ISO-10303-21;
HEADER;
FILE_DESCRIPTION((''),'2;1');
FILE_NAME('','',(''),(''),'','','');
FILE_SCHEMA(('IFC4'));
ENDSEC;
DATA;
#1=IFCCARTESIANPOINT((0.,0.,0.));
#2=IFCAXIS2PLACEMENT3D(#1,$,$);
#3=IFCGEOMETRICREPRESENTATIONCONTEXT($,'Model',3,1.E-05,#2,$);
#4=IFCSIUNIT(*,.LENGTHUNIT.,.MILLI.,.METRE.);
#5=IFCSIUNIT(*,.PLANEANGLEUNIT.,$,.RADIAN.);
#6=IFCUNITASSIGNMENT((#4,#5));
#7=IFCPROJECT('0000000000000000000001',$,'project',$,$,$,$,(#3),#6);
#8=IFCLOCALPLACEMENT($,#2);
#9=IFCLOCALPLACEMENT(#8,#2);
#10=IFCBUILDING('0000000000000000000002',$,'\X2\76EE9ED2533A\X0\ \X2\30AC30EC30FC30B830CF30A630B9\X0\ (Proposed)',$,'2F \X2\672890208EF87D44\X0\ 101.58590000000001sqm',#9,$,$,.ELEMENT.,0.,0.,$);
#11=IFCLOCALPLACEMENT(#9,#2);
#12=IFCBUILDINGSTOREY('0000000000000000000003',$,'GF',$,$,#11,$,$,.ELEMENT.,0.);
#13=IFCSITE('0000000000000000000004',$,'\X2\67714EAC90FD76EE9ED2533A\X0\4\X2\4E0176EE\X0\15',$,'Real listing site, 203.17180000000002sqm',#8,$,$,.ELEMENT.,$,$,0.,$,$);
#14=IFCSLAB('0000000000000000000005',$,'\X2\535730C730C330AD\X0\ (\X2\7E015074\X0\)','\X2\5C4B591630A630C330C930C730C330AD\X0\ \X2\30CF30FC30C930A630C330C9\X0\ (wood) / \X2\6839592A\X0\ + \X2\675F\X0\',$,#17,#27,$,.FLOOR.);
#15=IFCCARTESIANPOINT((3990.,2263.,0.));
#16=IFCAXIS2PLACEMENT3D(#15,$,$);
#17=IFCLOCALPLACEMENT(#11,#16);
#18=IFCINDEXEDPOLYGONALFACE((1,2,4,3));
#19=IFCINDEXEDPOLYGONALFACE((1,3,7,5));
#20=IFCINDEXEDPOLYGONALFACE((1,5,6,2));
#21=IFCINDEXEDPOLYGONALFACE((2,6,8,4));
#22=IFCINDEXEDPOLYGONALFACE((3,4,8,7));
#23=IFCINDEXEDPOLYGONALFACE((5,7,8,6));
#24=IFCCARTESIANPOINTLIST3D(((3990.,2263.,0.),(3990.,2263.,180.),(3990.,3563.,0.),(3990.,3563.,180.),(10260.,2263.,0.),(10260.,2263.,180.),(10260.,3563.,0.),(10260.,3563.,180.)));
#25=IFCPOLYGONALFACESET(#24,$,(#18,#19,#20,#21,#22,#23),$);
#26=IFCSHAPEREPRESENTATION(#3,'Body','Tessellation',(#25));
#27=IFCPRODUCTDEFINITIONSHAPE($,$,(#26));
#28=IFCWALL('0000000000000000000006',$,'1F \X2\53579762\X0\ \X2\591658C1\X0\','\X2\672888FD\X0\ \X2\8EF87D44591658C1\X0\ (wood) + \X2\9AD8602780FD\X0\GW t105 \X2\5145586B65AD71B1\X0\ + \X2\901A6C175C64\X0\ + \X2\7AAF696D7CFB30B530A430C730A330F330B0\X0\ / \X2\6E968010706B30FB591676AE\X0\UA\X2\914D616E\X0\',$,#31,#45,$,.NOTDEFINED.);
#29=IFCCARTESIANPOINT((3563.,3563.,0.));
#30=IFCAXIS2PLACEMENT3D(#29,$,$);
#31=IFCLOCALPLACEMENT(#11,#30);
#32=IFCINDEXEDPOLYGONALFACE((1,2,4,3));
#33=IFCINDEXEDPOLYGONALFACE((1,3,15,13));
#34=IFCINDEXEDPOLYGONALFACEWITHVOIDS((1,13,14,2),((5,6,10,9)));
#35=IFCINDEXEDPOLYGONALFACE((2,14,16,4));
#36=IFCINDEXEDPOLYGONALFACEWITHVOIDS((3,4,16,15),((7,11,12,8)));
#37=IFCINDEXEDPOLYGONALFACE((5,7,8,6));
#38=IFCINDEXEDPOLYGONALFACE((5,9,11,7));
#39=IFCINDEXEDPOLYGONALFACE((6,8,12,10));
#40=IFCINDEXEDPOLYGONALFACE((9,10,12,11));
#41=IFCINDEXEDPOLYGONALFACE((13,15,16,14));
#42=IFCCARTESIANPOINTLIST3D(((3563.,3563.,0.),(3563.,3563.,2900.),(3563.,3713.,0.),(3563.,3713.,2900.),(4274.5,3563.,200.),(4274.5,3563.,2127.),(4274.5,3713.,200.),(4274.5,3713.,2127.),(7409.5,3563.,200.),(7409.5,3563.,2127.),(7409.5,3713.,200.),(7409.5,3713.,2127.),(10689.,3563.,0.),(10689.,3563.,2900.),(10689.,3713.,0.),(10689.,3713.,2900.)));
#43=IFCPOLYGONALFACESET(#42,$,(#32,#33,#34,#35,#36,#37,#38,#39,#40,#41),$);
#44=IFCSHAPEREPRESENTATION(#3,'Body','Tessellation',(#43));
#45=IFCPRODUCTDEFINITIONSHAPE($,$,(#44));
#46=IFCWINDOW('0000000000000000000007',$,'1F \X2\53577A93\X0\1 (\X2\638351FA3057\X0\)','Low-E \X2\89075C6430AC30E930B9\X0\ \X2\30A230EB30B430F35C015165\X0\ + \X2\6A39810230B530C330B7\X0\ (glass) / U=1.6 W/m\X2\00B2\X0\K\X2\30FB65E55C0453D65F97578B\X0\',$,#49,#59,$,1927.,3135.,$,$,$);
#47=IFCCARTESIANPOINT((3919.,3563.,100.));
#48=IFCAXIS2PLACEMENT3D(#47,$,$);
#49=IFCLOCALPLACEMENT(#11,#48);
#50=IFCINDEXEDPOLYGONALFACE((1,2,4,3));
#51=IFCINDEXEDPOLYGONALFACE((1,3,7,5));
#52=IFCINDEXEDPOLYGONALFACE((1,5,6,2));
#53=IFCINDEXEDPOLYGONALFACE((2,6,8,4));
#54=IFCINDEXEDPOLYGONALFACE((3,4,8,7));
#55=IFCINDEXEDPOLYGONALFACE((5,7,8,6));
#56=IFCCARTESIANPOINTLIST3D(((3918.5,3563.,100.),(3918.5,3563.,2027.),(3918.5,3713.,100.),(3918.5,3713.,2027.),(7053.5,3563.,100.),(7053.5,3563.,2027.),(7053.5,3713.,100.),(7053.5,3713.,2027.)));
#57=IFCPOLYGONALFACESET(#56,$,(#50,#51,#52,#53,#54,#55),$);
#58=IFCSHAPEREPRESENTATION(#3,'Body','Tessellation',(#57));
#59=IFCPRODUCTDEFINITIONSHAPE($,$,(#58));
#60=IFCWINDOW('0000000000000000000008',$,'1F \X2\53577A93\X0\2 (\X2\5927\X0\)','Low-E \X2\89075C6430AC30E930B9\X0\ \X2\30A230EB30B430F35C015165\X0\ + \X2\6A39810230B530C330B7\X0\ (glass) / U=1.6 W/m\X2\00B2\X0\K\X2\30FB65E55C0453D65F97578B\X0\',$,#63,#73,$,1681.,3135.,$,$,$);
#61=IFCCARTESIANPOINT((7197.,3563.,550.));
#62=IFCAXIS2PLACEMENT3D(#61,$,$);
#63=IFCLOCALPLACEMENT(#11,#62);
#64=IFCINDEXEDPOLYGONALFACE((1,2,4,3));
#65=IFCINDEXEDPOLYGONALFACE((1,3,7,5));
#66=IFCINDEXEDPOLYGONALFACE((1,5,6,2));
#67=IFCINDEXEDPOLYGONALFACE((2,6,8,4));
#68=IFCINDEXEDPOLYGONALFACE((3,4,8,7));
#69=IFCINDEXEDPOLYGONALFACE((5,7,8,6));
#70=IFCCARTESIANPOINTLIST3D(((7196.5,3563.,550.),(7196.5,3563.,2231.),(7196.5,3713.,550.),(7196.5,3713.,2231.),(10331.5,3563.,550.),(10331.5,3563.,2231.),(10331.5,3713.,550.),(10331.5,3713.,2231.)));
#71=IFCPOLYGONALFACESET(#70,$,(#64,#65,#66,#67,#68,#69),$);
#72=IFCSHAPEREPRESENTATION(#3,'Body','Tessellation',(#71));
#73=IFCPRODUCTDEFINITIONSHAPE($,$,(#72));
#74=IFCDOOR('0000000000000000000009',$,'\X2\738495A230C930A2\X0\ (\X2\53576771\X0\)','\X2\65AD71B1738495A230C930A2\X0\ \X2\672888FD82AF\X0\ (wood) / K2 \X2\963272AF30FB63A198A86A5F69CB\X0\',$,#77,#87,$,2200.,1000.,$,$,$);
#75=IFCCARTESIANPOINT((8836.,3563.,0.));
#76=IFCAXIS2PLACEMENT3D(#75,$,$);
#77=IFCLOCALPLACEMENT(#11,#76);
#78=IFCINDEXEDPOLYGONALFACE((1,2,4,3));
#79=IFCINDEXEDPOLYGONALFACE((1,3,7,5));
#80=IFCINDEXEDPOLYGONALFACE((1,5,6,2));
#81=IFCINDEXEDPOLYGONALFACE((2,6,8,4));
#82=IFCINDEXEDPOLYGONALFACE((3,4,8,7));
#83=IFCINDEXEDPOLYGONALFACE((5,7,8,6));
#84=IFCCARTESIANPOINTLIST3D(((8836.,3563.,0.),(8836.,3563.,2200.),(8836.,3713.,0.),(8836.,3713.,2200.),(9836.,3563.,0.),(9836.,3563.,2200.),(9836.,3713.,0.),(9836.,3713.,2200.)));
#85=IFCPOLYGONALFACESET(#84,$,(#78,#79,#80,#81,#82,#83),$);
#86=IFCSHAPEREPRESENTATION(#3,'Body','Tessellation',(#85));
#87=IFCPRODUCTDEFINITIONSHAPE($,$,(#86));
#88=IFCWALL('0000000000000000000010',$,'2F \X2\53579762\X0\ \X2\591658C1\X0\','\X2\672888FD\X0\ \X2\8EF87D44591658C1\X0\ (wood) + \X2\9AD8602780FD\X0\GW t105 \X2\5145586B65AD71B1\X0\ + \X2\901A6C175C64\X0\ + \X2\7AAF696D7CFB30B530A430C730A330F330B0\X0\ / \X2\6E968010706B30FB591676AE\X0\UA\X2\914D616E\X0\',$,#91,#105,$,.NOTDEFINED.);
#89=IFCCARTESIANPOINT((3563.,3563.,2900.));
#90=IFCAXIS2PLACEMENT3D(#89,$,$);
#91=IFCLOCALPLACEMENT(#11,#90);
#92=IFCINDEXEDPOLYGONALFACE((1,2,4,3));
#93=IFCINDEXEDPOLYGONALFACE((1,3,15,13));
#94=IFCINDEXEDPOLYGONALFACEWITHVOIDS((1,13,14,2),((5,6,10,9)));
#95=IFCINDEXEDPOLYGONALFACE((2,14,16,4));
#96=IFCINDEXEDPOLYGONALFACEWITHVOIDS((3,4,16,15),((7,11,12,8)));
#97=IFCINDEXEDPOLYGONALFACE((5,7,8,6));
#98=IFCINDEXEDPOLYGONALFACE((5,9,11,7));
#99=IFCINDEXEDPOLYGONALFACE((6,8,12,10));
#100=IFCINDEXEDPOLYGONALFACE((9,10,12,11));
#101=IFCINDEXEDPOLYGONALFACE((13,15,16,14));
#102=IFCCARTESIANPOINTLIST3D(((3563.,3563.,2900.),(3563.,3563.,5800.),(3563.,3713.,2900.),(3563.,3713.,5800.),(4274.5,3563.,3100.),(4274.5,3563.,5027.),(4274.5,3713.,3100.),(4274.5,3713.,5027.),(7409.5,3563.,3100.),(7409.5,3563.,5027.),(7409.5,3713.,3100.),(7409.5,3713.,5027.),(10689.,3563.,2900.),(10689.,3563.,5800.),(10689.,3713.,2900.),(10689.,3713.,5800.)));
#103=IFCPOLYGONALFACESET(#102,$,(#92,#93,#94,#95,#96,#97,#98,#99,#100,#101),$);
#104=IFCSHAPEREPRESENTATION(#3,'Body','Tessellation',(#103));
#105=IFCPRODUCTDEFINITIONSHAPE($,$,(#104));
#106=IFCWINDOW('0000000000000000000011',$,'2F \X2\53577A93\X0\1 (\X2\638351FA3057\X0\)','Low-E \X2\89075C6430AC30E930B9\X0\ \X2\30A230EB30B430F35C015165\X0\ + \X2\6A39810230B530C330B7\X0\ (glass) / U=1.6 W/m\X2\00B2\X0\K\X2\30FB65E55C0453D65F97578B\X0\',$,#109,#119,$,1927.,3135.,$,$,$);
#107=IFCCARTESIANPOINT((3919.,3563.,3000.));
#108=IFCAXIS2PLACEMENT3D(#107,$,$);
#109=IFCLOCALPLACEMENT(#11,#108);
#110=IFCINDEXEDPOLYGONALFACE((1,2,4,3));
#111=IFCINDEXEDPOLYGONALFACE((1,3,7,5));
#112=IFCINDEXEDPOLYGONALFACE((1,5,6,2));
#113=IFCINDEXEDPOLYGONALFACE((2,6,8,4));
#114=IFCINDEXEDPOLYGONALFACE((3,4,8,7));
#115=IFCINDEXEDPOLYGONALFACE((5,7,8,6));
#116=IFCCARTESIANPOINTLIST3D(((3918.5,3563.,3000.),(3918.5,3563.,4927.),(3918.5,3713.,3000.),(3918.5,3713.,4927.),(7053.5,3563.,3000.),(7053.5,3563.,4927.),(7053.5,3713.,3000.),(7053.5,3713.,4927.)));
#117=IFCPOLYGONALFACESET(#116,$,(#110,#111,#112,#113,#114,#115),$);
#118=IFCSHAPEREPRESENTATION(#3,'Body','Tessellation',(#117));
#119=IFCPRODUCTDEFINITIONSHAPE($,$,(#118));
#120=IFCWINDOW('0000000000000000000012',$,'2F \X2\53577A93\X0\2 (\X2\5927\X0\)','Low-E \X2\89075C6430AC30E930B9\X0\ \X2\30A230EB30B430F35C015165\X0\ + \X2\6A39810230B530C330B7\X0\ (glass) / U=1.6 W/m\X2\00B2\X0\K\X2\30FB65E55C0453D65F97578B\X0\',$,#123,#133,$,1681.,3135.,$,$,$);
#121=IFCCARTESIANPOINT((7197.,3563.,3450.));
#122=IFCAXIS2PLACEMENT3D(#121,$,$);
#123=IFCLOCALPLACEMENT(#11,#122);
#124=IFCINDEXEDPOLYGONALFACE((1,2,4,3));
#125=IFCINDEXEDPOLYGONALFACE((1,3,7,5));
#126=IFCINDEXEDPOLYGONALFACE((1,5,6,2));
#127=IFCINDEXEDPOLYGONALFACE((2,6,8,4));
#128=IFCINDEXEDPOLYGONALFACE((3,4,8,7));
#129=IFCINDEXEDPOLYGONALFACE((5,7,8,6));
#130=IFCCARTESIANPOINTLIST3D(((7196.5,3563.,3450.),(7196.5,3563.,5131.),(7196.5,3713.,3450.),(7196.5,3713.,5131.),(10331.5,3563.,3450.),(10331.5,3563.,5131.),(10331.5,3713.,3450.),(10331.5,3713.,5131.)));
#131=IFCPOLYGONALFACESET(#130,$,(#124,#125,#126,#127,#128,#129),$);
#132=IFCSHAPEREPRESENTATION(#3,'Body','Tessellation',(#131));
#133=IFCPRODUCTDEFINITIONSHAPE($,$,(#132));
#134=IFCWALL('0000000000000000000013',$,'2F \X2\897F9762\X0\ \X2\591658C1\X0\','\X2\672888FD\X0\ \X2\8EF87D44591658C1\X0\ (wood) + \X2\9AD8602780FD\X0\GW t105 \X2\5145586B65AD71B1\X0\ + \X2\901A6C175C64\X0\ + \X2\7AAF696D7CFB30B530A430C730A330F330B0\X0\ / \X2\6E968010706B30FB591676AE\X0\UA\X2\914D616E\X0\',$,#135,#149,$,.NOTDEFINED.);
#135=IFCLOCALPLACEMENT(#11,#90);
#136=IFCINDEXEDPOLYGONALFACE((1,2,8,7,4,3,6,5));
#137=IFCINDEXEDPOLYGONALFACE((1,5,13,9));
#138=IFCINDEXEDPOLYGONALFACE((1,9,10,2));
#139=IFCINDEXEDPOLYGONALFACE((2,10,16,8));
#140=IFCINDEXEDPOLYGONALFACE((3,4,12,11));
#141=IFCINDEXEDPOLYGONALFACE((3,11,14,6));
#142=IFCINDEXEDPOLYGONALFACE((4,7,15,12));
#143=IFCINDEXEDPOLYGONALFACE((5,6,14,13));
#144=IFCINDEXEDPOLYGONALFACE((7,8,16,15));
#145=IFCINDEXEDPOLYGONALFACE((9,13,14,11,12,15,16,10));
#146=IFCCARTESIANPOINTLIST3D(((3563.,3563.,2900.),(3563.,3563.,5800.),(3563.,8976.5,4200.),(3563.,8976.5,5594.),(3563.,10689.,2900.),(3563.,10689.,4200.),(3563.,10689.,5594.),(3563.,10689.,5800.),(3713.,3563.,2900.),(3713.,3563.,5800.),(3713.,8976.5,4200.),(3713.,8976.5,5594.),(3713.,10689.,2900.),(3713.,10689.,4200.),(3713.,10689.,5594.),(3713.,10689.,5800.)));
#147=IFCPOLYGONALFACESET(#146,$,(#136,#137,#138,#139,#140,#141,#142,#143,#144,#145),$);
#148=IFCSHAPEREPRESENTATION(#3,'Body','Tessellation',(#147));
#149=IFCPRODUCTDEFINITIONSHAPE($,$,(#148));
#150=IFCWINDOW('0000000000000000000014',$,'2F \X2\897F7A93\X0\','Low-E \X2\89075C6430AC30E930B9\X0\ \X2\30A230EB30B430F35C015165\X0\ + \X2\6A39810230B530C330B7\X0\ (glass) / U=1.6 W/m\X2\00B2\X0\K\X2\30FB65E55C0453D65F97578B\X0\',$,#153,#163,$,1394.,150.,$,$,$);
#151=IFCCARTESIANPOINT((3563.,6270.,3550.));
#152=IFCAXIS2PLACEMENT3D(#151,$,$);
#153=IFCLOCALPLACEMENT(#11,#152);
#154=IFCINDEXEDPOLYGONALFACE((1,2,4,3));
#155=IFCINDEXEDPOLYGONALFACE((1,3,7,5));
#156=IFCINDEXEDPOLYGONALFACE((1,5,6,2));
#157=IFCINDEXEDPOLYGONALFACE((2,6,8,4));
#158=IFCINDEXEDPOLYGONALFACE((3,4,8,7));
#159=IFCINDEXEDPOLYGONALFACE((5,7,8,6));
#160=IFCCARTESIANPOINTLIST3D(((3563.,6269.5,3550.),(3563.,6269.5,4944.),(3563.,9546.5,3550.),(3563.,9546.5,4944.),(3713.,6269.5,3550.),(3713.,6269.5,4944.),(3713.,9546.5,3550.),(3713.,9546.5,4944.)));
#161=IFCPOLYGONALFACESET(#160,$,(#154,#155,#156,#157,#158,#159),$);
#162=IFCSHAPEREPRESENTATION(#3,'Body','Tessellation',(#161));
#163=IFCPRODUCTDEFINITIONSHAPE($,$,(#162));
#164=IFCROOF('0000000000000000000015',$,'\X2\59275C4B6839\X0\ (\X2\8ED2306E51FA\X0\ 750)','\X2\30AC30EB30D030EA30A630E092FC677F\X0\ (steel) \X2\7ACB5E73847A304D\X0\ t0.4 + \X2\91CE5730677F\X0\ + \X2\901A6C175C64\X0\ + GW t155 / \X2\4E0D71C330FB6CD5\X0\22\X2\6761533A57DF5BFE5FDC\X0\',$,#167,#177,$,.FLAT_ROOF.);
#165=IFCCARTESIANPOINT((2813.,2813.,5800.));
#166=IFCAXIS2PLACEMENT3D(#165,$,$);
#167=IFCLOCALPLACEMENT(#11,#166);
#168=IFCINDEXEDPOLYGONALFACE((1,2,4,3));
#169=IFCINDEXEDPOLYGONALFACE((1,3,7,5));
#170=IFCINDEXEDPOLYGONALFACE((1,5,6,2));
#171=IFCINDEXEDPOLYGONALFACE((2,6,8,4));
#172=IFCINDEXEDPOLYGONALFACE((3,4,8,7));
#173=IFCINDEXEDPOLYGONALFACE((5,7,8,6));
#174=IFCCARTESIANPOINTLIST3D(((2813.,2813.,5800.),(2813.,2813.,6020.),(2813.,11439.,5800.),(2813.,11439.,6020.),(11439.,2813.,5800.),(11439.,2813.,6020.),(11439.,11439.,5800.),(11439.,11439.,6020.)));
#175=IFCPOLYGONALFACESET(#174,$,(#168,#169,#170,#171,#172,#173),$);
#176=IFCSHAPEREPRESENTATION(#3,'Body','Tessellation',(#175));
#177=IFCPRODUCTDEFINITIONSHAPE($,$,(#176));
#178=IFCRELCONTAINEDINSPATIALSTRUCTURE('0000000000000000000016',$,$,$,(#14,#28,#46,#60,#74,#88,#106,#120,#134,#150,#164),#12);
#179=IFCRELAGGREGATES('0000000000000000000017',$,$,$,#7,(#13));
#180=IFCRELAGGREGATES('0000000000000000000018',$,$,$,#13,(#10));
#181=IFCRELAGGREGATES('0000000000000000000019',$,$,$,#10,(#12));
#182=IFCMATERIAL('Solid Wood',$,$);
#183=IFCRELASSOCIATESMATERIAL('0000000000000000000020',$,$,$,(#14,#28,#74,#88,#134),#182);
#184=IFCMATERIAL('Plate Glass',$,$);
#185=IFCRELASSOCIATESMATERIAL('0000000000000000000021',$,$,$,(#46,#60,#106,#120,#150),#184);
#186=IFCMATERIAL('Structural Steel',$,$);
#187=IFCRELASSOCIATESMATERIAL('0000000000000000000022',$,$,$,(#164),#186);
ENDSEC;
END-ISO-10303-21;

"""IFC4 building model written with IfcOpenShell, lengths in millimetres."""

from ifc_helpers import new_model, si_unit, frame, frame_2d, origin, place, context, project, spatial, rectangle, extrude, material, element, fill, save


model = new_model("IFC4")

# Units and contexts
model_context = context("Model", 3, precision=1e-05, world=origin())
ifc_project = project(units=[si_unit("LENGTHUNIT", "METRE", prefix="MILLI"), si_unit("PLANEANGLEUNIT", "RADIAN")], contexts=[model_context])

# Site, building, storey
site_placement = place(None, origin())
site = spatial("IfcSite", under=ifc_project, at=site_placement, Name="東京都目黒区4丁目15", ObjectType="Real listing site, 203.17180000000002sqm", CompositionType="ELEMENT", RefElevation=0.0)
building_placement = place(site_placement, origin())
building = spatial("IfcBuilding", under=site, at=building_placement, Name="目黒区 ガレージハウス (Proposed)", ObjectType="2F 木造軸組 101.58590000000001sqm", CompositionType="ELEMENT", ElevationOfRefHeight=0.0, ElevationOfTerrain=0.0)
storey_placement = place(building_placement, origin())
storey = spatial("IfcBuildingStorey", under=building, at=storey_placement, Name="GF", CompositionType="ELEMENT", Elevation=0.0)

# Slab
ifc_material_1 = material(Name="Solid Wood")
slab_1_placement = place(storey_placement, frame((3990.0, 2263.0, 0.0)))
element("IfcSlab", 1, at=slab_1_placement, inside=storey, material=ifc_material_1, Name="南デッキ (縁側)", Description="屋外ウッドデッキ ハードウッド (wood) / 根太 + 束", PredefinedType="FLOOR", context=model_context, shape_type="SweptSolid", body=[
    extrude(rectangle(XDim=6270.0, YDim=1300.0, at=frame_2d((3135.0, 650.0))), frame((3990.0, 2263.0, 0.0)), (0.0, 0.0, 1.0), 180.0),
])

# Wall, openings, windows, door
wall_1_placement = place(storey_placement, frame((3563.0, 3563.0, 0.0)))
wall_1 = element("IfcWall", 2, at=wall_1_placement, inside=storey, material=ifc_material_1, Name="1F 南面 外壁", Description="木製 軸組外壁 (wood) + 高性能GW t105 充填断熱 + 通気層 + 窯業系サイディング / 準耐火・外皮UA配慮", PredefinedType="NOTDEFINED", context=model_context, shape_type="SweptSolid", body=[
    extrude(rectangle(XDim=7126.0, YDim=150.0, at=frame_2d((3563.0, 75.0))), frame((3563.0, 3563.0, 0.0)), (0.0, 0.0, 1.0), 2900.0),
])
opening_1_placement = place(storey_placement, frame((3919.0, 3563.0, 100.0)))
opening_1 = element("IfcOpeningElement", 3, at=opening_1_placement, cuts=wall_1, PredefinedType="NOTDEFINED", context=model_context, shape_type="SweptSolid", body=[
    extrude(rectangle(XDim=3135.0, YDim=150.0, at=frame_2d((1567.0, 75.0))), frame((3919.0, 3563.0, 100.0)), (0.0, 0.0, 1.0), 1927.0),
])
opening_2_placement = place(storey_placement, frame((7197.0, 3563.0, 550.0)))
opening_2 = element("IfcOpeningElement", 4, at=opening_2_placement, cuts=wall_1, PredefinedType="NOTDEFINED", context=model_context, shape_type="SweptSolid", body=[
    extrude(rectangle(XDim=3135.0, YDim=150.0, at=frame_2d((1567.0, 75.0))), frame((7197.0, 3563.0, 550.0)), (0.0, 0.0, 1.0), 1681.0),
])
opening_3_placement = place(storey_placement, frame((8836.0, 3563.0, 0.0)))
opening_3 = element("IfcOpeningElement", 5, at=opening_3_placement, cuts=wall_1, PredefinedType="NOTDEFINED", context=model_context, shape_type="SweptSolid", body=[
    extrude(rectangle(XDim=1000.0, YDim=150.0, at=frame_2d((500.0, 75.0))), frame((8836.0, 3563.0, 0.0)), (0.0, 0.0, 1.0), 2200.0),
])
ifc_material_2 = material(Name="Plate Glass")
window_1_placement = place(storey_placement, frame((3919.0, 3563.0, 100.0)))
window_1 = element("IfcWindow", 6, at=window_1_placement, inside=storey, material=ifc_material_2, Name="1F 南窓1 (掃出し)", Description="Low-E 複層ガラス アルゴン封入 + 樹脂サッシ (glass) / U=1.6 W/m²K・日射取得型", OverallHeight=1927.0, OverallWidth=3135.0, context=model_context, shape_type="SweptSolid", body=[
    extrude(rectangle(XDim=3135.0, YDim=150.0, at=frame_2d((1567.0, 75.0))), frame((3919.0, 3563.0, 100.0)), (0.0, 0.0, 1.0), 1927.0),
])
fill(opening_1, window_1)
window_2_placement = place(storey_placement, frame((7197.0, 3563.0, 550.0)))
window_2 = element("IfcWindow", 7, at=window_2_placement, inside=storey, material=ifc_material_2, Name="1F 南窓2 (大)", Description="Low-E 複層ガラス アルゴン封入 + 樹脂サッシ (glass) / U=1.6 W/m²K・日射取得型", OverallHeight=1681.0, OverallWidth=3135.0, context=model_context, shape_type="SweptSolid", body=[
    extrude(rectangle(XDim=3135.0, YDim=150.0, at=frame_2d((1567.0, 75.0))), frame((7197.0, 3563.0, 550.0)), (0.0, 0.0, 1.0), 1681.0),
])
fill(opening_2, window_2)
door_placement = place(storey_placement, frame((8836.0, 3563.0, 0.0)))
door = element("IfcDoor", 8, at=door_placement, inside=storey, material=ifc_material_1, Name="玄関ドア (南東)", Description="断熱玄関ドア 木製芯 (wood) / K2 防犯・採風機構", OverallHeight=2200.0, OverallWidth=1000.0, context=model_context, shape_type="SweptSolid", body=[
    extrude(rectangle(XDim=1000.0, YDim=150.0, at=frame_2d((500.0, 75.0))), frame((8836.0, 3563.0, 0.0)), (0.0, 0.0, 1.0), 2200.0),
])
fill(opening_3, door)

# Wall, openings, windows
wall_2_placement = place(storey_placement, frame((3563.0, 3563.0, 2900.0)))
wall_2 = element("IfcWall", 9, at=wall_2_placement, inside=storey, material=ifc_material_1, Name="2F 南面 外壁", Description="木製 軸組外壁 (wood) + 高性能GW t105 充填断熱 + 通気層 + 窯業系サイディング / 準耐火・外皮UA配慮", PredefinedType="NOTDEFINED", context=model_context, shape_type="SweptSolid", body=[
    extrude(rectangle(XDim=7126.0, YDim=150.0, at=frame_2d((3563.0, 75.0))), frame((3563.0, 3563.0, 2900.0)), (0.0, 0.0, 1.0), 2900.0),
])
opening_4_placement = place(storey_placement, frame((3919.0, 3563.0, 3000.0)))
opening_4 = element("IfcOpeningElement", 10, at=opening_4_placement, cuts=wall_2, PredefinedType="NOTDEFINED", context=model_context, shape_type="SweptSolid", body=[
    extrude(rectangle(XDim=3135.0, YDim=150.0, at=frame_2d((1567.0, 75.0))), frame((3919.0, 3563.0, 3000.0)), (0.0, 0.0, 1.0), 1927.0),
])
opening_5_placement = place(storey_placement, frame((7197.0, 3563.0, 3450.0)))
opening_5 = element("IfcOpeningElement", 11, at=opening_5_placement, cuts=wall_2, PredefinedType="NOTDEFINED", context=model_context, shape_type="SweptSolid", body=[
    extrude(rectangle(XDim=3135.0, YDim=150.0, at=frame_2d((1567.0, 75.0))), frame((7197.0, 3563.0, 3450.0)), (0.0, 0.0, 1.0), 1681.0),
])
window_3_placement = place(storey_placement, frame((3919.0, 3563.0, 3000.0)))
window_3 = element("IfcWindow", 12, at=window_3_placement, inside=storey, material=ifc_material_2, Name="2F 南窓1 (掃出し)", Description="Low-E 複層ガラス アルゴン封入 + 樹脂サッシ (glass) / U=1.6 W/m²K・日射取得型", OverallHeight=1927.0, OverallWidth=3135.0, context=model_context, shape_type="SweptSolid", body=[
    extrude(rectangle(XDim=3135.0, YDim=150.0, at=frame_2d((1567.0, 75.0))), frame((3919.0, 3563.0, 3000.0)), (0.0, 0.0, 1.0), 1927.0),
])
fill(opening_4, window_3)
window_4_placement = place(storey_placement, frame((7197.0, 3563.0, 3450.0)))
window_4 = element("IfcWindow", 13, at=window_4_placement, inside=storey, material=ifc_material_2, Name="2F 南窓2 (大)", Description="Low-E 複層ガラス アルゴン封入 + 樹脂サッシ (glass) / U=1.6 W/m²K・日射取得型", OverallHeight=1681.0, OverallWidth=3135.0, context=model_context, shape_type="SweptSolid", body=[
    extrude(rectangle(XDim=3135.0, YDim=150.0, at=frame_2d((1567.0, 75.0))), frame((7197.0, 3563.0, 3450.0)), (0.0, 0.0, 1.0), 1681.0),
])
fill(opening_5, window_4)

# Wall, opening, window
wall_3_placement = place(storey_placement, frame((3563.0, 3563.0, 2900.0)))
wall_3 = element("IfcWall", 14, at=wall_3_placement, inside=storey, material=ifc_material_1, Name="2F 西面 外壁", Description="木製 軸組外壁 (wood) + 高性能GW t105 充填断熱 + 通気層 + 窯業系サイディング / 準耐火・外皮UA配慮", PredefinedType="NOTDEFINED", context=model_context, shape_type="SweptSolid", body=[
    extrude(rectangle(XDim=150.0, YDim=7126.0, at=frame_2d((75.0, 3563.0))), frame((3563.0, 3563.0, 2900.0)), (0.0, 0.0, 1.0), 2900.0),
])
opening_6_placement = place(storey_placement, frame((3563.0, 6270.0, 3550.0)))
opening_6 = element("IfcOpeningElement", 15, at=opening_6_placement, cuts=wall_3, PredefinedType="NOTDEFINED", context=model_context, shape_type="SweptSolid", body=[
    extrude(rectangle(XDim=150.0, YDim=3277.0, at=frame_2d((75.0, 1638.0))), frame((3563.0, 6270.0, 3550.0)), (0.0, 0.0, 1.0), 1394.0),
])
window_5_placement = place(storey_placement, frame((3563.0, 6270.0, 3550.0)))
window_5 = element("IfcWindow", 16, at=window_5_placement, inside=storey, material=ifc_material_2, Name="2F 西窓", Description="Low-E 複層ガラス アルゴン封入 + 樹脂サッシ (glass) / U=1.6 W/m²K・日射取得型", OverallHeight=1394.0, OverallWidth=150.0, context=model_context, shape_type="SweptSolid", body=[
    extrude(rectangle(XDim=150.0, YDim=3277.0, at=frame_2d((75.0, 1638.0))), frame((3563.0, 6270.0, 3550.0)), (0.0, 0.0, 1.0), 1394.0),
])
fill(opening_6, window_5)

# Roof
ifc_material_3 = material(Name="Structural Steel")
roof_placement = place(storey_placement, frame((2813.0, 2813.0, 5800.0)))
element("IfcRoof", 17, at=roof_placement, inside=storey, material=ifc_material_3, Name="大屋根 (軒の出 750)", Description="ガルバリウム鋼板 (steel) 立平葺き t0.4 + 野地板 + 通気層 + GW t155 / 不燃・法22条区域対応", PredefinedType="FLAT_ROOF", context=model_context, shape_type="SweptSolid", body=[
    extrude(rectangle(XDim=8626.0, YDim=8626.0, at=frame_2d((4313.0, 4313.0))), frame((2813.0, 2813.0, 5800.0)), (0.0, 0.0, 1.0), 220.0),
])

save(model, "model.ifc")
